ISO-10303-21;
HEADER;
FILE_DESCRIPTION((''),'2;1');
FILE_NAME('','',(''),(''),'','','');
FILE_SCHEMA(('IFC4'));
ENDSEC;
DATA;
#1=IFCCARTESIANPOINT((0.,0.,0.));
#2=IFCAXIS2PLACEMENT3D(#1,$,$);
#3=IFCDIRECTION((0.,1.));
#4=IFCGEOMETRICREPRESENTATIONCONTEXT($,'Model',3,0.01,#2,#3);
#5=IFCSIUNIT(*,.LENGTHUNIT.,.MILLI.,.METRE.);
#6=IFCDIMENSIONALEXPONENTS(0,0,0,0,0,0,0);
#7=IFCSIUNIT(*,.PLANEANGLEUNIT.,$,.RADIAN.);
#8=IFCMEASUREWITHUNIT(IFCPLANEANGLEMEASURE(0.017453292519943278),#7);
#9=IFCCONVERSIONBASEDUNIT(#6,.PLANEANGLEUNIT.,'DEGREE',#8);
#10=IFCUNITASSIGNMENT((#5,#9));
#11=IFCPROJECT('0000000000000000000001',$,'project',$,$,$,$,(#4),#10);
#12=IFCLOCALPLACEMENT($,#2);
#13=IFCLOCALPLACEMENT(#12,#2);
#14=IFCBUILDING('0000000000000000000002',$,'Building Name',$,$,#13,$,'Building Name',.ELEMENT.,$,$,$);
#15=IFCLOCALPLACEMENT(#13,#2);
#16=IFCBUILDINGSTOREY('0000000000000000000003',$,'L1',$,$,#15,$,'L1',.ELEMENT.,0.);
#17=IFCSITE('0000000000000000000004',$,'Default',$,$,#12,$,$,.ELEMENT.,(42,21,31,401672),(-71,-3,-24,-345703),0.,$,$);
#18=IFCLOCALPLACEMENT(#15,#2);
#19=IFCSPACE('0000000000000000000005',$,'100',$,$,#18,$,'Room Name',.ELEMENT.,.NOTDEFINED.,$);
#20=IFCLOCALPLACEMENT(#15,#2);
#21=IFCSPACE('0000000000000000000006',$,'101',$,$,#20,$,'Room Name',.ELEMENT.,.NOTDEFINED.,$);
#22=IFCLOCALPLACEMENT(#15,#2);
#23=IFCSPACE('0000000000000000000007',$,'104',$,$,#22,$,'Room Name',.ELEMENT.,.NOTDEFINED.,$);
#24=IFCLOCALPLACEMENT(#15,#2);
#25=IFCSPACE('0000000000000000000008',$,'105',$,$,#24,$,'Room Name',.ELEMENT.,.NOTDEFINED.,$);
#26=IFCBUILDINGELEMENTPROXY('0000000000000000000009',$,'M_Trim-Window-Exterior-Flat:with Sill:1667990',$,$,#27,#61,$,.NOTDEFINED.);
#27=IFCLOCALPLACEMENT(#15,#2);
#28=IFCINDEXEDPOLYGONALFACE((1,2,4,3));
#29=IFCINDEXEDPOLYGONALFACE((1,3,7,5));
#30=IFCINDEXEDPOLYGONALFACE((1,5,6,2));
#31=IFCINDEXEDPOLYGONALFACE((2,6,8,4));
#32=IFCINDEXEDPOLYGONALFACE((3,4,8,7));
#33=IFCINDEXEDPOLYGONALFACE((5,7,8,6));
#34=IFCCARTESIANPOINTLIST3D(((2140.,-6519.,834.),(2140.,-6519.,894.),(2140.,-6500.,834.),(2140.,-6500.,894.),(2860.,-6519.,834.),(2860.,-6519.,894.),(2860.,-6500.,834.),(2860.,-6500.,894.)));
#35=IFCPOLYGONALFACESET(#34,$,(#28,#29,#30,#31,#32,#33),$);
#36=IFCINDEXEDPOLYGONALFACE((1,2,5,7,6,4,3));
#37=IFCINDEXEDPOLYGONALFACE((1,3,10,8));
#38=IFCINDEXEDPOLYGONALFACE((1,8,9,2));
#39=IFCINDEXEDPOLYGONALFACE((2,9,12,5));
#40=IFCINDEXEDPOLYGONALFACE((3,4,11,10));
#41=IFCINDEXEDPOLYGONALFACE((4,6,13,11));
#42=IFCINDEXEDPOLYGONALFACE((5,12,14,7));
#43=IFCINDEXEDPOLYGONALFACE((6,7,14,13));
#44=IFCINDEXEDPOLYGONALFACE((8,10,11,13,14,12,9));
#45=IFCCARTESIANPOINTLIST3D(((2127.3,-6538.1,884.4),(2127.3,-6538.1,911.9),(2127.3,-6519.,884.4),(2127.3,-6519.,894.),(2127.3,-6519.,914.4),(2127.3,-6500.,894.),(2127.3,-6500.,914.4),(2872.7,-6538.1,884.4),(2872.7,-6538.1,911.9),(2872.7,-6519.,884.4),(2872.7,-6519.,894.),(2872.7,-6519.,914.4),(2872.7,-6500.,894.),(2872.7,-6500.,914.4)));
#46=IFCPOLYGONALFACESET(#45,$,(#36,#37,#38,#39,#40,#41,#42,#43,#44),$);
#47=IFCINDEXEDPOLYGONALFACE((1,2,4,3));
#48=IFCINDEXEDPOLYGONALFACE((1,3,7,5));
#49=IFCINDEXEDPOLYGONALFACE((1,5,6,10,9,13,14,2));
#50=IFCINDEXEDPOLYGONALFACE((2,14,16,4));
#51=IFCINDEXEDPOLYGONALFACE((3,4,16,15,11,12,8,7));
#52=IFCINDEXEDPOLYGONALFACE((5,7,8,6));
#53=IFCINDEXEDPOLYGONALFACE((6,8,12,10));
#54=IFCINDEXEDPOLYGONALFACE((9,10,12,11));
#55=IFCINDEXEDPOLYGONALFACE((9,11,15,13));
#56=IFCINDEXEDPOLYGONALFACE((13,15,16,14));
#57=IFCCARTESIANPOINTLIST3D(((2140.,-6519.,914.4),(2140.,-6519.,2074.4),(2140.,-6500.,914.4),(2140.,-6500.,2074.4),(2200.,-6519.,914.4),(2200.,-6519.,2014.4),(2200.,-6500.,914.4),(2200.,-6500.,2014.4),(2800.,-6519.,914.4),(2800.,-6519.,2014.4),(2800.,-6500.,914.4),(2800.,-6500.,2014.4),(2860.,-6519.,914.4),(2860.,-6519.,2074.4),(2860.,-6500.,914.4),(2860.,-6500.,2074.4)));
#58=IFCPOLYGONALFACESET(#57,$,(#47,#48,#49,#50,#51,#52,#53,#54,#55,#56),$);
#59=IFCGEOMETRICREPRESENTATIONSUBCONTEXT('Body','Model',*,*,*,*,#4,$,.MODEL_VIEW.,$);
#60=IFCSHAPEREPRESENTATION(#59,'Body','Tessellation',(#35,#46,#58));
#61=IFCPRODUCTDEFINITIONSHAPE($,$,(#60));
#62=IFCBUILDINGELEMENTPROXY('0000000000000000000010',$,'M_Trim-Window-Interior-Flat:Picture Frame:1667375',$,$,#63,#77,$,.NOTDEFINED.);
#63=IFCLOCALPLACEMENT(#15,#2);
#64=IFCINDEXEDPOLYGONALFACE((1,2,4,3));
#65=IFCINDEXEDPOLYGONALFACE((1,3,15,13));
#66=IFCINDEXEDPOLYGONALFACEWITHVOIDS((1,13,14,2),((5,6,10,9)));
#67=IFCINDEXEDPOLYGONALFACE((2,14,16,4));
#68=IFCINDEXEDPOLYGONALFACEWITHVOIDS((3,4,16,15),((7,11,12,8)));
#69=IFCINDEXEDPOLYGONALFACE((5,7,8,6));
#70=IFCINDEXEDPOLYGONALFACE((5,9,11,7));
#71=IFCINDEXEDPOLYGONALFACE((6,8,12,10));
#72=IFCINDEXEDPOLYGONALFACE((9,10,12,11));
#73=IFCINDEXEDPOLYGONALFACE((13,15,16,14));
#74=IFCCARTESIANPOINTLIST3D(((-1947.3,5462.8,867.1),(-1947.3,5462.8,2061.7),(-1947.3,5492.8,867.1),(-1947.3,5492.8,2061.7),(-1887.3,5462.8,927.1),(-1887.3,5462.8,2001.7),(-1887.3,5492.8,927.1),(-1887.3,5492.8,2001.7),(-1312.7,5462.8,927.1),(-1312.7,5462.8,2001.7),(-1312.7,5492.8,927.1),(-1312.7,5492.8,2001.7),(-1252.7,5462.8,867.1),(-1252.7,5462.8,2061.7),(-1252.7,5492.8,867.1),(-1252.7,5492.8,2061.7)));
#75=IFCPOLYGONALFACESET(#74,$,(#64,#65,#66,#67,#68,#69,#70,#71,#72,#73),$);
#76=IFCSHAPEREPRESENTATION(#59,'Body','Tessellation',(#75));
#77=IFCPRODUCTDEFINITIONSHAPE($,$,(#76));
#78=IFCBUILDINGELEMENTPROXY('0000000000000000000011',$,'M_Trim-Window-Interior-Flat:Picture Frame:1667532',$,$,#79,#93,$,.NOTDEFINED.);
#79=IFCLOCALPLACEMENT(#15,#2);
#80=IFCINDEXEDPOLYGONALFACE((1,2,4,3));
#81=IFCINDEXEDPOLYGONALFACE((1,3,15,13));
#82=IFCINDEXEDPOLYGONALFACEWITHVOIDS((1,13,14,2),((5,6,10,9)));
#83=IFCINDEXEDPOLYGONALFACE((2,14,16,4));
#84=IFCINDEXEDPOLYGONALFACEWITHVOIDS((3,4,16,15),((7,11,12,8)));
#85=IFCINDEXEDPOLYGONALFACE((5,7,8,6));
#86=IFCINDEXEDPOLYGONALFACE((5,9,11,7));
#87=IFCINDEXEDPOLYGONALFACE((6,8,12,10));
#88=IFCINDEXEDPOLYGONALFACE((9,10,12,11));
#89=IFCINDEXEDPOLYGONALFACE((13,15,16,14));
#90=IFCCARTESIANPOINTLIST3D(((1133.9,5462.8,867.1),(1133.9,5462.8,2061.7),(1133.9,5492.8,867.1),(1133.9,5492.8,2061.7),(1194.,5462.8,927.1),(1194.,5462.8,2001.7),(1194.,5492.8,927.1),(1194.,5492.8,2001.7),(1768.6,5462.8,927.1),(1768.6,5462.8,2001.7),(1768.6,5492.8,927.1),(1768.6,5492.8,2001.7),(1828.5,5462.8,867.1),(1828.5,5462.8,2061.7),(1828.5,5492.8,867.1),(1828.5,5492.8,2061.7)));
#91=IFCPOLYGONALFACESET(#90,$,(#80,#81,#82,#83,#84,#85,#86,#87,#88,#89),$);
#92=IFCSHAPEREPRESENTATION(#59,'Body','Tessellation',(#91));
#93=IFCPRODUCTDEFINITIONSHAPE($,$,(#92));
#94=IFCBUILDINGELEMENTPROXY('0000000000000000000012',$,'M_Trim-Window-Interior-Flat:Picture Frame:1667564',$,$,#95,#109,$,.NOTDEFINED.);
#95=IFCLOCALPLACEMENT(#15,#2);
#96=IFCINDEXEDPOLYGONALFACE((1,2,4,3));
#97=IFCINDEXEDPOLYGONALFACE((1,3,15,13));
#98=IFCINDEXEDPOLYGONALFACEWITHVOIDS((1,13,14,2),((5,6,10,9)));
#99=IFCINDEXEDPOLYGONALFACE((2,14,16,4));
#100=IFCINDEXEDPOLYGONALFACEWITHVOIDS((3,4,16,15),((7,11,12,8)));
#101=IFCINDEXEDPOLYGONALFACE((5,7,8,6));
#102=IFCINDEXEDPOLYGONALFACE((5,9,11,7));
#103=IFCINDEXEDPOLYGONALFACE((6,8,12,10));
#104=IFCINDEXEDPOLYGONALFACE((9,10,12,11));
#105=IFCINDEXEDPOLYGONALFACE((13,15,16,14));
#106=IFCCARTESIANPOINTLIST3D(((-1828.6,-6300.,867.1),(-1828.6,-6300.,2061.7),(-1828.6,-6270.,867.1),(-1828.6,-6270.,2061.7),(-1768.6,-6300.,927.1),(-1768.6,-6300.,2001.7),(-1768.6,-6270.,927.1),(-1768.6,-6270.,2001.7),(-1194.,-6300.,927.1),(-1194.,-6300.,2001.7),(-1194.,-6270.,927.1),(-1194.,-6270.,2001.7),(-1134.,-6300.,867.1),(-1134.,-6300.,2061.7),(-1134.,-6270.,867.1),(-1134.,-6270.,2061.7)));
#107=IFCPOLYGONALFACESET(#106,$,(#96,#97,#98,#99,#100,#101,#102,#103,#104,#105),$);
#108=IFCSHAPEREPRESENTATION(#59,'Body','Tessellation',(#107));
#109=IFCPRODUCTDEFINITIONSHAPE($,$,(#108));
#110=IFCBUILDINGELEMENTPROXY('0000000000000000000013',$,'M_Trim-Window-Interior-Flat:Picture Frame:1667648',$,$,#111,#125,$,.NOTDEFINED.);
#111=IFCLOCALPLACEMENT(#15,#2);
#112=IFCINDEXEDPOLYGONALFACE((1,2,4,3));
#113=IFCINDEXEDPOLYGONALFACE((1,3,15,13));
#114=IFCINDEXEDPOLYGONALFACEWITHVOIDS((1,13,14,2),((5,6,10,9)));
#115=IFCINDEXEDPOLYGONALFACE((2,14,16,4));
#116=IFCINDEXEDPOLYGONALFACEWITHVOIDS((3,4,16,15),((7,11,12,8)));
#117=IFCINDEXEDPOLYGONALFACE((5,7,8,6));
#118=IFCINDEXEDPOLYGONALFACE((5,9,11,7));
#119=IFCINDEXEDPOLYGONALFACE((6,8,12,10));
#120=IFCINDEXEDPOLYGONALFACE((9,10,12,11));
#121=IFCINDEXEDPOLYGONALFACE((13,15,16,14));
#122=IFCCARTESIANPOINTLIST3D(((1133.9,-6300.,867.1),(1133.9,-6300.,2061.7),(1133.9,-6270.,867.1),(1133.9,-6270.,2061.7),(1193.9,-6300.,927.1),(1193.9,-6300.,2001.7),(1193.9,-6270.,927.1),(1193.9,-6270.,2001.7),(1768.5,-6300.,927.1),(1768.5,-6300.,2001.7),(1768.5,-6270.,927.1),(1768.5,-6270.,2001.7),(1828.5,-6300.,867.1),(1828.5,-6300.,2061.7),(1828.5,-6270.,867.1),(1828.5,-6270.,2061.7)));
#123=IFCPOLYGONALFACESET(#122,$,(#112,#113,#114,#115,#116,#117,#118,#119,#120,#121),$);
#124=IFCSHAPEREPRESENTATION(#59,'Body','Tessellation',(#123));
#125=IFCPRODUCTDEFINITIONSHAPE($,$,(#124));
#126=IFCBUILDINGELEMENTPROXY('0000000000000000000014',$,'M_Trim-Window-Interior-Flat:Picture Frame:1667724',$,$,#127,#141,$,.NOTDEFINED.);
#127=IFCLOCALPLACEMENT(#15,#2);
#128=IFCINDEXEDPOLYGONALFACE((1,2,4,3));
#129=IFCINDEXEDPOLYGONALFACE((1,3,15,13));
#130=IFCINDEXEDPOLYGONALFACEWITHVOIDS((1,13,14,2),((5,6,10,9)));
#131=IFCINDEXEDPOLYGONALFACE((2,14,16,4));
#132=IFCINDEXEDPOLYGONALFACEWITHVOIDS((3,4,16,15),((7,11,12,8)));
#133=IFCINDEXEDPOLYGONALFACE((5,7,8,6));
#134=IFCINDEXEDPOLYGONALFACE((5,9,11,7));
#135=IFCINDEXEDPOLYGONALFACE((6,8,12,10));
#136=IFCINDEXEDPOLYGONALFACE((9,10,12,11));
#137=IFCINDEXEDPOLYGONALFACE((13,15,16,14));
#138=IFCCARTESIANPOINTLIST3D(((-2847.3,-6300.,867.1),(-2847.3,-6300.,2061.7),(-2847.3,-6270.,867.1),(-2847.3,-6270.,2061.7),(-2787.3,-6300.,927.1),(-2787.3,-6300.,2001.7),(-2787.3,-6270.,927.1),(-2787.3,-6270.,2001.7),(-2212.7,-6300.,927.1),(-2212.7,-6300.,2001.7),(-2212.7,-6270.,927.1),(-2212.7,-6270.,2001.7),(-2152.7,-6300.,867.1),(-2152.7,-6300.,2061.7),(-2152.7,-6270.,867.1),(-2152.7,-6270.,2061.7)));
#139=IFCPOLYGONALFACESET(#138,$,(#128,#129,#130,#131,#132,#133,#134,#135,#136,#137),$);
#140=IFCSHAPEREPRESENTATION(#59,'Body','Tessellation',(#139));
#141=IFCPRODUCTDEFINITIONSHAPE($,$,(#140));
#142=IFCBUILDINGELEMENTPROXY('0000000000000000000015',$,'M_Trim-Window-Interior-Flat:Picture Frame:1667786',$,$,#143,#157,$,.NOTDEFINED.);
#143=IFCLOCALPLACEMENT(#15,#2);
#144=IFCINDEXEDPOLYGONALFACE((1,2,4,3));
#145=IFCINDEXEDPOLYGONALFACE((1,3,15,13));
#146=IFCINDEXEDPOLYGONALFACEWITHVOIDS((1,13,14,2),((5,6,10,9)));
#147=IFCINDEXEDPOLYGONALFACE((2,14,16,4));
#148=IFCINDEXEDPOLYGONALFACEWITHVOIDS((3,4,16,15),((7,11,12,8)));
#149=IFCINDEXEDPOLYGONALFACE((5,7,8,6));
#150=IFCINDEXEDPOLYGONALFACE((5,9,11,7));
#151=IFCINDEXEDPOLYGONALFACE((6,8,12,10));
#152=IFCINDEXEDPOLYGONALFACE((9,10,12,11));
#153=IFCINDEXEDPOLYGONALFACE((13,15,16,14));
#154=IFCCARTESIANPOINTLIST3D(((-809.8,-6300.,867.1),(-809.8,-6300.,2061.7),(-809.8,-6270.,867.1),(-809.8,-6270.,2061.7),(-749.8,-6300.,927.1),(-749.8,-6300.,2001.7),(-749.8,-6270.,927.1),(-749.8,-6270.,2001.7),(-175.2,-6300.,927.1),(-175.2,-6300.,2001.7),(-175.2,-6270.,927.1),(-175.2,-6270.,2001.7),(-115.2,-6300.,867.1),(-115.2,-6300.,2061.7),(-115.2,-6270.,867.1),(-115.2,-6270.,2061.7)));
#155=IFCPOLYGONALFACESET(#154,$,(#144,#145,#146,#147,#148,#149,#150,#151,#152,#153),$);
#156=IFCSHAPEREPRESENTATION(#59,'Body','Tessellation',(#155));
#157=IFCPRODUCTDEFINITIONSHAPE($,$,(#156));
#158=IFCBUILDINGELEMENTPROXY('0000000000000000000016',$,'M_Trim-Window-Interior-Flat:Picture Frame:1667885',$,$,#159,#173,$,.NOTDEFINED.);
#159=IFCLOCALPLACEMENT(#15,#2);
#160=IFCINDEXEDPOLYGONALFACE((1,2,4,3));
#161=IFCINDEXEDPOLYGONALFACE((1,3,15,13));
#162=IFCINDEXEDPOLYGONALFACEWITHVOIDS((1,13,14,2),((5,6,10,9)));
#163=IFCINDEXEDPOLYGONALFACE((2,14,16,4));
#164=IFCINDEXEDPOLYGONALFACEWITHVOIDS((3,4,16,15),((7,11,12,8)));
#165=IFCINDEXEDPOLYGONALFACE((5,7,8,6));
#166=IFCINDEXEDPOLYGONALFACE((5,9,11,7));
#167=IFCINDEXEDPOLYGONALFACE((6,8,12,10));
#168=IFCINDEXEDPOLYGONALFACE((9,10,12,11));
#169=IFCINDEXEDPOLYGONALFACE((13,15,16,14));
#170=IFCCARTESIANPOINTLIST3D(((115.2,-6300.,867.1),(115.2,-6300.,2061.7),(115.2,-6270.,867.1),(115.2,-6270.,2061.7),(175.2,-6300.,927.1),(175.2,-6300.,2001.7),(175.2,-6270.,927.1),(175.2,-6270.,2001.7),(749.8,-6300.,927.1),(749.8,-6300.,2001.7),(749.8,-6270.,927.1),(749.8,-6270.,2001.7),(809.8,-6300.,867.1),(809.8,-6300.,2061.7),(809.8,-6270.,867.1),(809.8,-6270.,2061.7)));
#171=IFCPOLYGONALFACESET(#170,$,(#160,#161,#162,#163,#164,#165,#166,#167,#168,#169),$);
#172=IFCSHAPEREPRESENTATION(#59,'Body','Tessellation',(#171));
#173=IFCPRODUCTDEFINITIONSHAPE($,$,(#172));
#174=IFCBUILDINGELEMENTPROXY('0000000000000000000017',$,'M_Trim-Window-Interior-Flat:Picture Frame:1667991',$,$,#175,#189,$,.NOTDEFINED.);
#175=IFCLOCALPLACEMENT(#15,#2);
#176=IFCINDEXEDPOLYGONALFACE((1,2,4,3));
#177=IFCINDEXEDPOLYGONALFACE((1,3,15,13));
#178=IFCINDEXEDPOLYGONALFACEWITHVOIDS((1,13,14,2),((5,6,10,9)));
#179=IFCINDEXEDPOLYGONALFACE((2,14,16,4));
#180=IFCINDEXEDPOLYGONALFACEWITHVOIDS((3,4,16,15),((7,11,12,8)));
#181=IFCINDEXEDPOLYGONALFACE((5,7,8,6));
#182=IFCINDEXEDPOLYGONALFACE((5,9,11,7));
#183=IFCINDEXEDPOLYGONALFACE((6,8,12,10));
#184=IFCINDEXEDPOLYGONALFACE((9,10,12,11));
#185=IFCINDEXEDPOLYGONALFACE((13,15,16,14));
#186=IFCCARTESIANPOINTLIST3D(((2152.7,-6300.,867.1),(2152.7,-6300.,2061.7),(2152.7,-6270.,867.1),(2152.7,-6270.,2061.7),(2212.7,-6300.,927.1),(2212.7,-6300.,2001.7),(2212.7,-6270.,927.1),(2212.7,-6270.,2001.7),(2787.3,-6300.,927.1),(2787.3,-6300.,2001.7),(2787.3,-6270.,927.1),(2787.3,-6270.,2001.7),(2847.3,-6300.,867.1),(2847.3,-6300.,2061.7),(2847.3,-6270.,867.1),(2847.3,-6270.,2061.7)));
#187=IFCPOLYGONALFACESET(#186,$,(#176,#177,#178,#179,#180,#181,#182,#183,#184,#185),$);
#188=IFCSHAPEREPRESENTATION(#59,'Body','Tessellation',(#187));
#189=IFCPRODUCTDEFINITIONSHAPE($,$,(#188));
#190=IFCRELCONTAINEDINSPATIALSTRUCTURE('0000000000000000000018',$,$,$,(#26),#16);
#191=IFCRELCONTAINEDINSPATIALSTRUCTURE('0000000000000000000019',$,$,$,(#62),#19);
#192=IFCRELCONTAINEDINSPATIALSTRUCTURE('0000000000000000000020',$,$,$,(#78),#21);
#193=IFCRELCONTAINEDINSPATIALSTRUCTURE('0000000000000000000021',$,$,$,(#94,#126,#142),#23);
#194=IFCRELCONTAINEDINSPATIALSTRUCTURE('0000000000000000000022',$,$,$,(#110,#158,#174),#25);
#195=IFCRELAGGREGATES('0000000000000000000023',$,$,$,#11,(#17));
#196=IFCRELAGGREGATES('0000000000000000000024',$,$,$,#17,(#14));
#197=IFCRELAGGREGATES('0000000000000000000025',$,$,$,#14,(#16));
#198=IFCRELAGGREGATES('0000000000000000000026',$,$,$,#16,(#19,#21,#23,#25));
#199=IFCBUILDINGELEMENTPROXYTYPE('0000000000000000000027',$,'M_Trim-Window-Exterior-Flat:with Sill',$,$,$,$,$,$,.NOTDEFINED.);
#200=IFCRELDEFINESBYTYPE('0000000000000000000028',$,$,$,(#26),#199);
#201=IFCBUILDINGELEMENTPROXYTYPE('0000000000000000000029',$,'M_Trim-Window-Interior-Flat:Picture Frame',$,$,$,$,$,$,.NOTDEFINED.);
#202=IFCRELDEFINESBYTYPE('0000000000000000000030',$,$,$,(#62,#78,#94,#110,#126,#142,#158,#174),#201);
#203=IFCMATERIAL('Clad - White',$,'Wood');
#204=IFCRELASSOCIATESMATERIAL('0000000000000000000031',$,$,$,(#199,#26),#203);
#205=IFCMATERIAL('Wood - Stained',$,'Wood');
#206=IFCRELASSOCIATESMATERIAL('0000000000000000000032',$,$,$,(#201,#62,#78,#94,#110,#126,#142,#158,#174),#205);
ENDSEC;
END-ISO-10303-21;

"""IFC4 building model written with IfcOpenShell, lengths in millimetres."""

from ifc_helpers import new_model, entity, si_unit, converted_unit, direction, frame, origin, place, context, subcontext, project, spatial, indexed_curve, outline, extrude, source, transform, mapped, material, type_object, type_shapes, element, save


model = new_model("IFC4")

# Units and contexts
model_context = context("Model", 3, precision=0.01, world=origin(), true_north=direction((0.0, 1.0)))
body_context = subcontext(model_context, "Body", "Model", "MODEL_VIEW")
ifc_project = project(units=[si_unit("LENGTHUNIT", "METRE", prefix="MILLI"), converted_unit("PLANEANGLEUNIT", "DEGREE", entity("IfcPlaneAngleMeasure", 0.017453292519943278), si_unit("PLANEANGLEUNIT", "RADIAN"), dimensions=[0, 0, 0, 0, 0, 0, 0])], contexts=[model_context])

# Site, building, storey
site_placement = place(None, origin())
site = spatial("IfcSite", under=ifc_project, at=site_placement, Name="Default", CompositionType="ELEMENT", RefLatitude=(42, 21, 31, 401672), RefLongitude=(-71, -3, -24, -345703), RefElevation=0.0)
building_placement = place(site_placement, origin())
building = spatial("IfcBuilding", under=site, at=building_placement, Name="Building Name", LongName="Building Name", CompositionType="ELEMENT")
storey_placement = place(building_placement, origin())
storey = spatial("IfcBuildingStorey", under=building, at=storey_placement, Name="L1", LongName="L1", CompositionType="ELEMENT", Elevation=0.0)

# Building element proxy
ifc_material_1 = material(Name="Clad - White", Category="Wood")
ifc_material_2 = material(Name="Wood - Stained", Category="Wood")
building_element_proxy_type_1 = type_object("IfcBuildingElementProxyType", Name="M_Trim-Window-Exterior-Flat:with Sill", PredefinedType="NOTDEFINED", material=ifc_material_1)
shared_shape_1 = source(origin(), body_context, "Body", "SweptSolid", [
    extrude(outline(indexed_curve([(-360.0, -30.0), (360.0, -30.0), (360.0, 30.0), (-360.0, 30.0), (-360.0, -30.0)], self_intersect=False)), frame((0.0, -1150.4, 0.0), z_axis=(0.0, 0.0, 1.0), x_axis=(-1.0, 0.0, 0.0)), (0.0, 0.0, 1.0), 19.0),
    extrude(outline(indexed_curve([(-19.0, -15.2), (0.0, -15.2), (0.0, -5.7), (19.0, -5.7), (19.0, 14.8), (0.0, 14.8), (-19.0, 12.3), (-19.0, -15.2)], self_intersect=False)), frame((-372.7, -1114.8, 19.0), z_axis=(1.0, 0.0, 0.0), x_axis=(0.0, 0.0, -1.0)), (0.0, 0.0, 1.0), 745.4),
    extrude(outline(indexed_curve([(-595.0, -360.0), (565.0, -360.0), (565.0, -300.0), (-535.0, -300.0), (-535.0, 300.0), (565.0, 300.0), (565.0, 360.0), (-595.0, 360.0), (-595.0, -360.0)], self_intersect=False)), frame((0.0, -535.0, 0.0), z_axis=(0.0, 0.0, 1.0), x_axis=(0.0, -1.0, 0.0)), (0.0, 0.0, 1.0), 19.0),
])
type_shapes(building_element_proxy_type_1, [shared_shape_1])
for number, where, z_axis, x_axis, name in (
    (1, (2500.0, -6500.0, 2014.4), (0.0, -1.0, 0.0), (1.0, 0.0, 0.0), "M_Trim-Window-Exterior-Flat:with Sill:1667990"),
):
    element("IfcBuildingElementProxy", number, at=place(storey_placement, frame(where, z_axis=z_axis, x_axis=x_axis)), inside=storey, type_object=building_element_proxy_type_1, material=ifc_material_1, Name=name, PredefinedType="NOTDEFINED", context=body_context, shape_type="MappedRepresentation", body=[
        mapped(shared_shape_1, transform((0.0, 0.0, 0.0), scale=1.0)),
    ])

# Shared definitions
space_1_placement = place(storey_placement, origin())
space_1 = spatial("IfcSpace", under=storey, at=space_1_placement, Name="100", LongName="Room Name", CompositionType="ELEMENT", PredefinedType="NOTDEFINED")

# Building element proxy
building_element_proxy_type_2 = type_object("IfcBuildingElementProxyType", Name="M_Trim-Window-Interior-Flat:Picture Frame", PredefinedType="NOTDEFINED", material=ifc_material_2)
shared_shape_2 = source(origin(), body_context, "Body", "SweptSolid", [
    extrude(outline(indexed_curve([(-347.3, -597.3), (347.3, -597.3), (347.3, 597.3), (-347.3, 597.3), (-347.3, -597.3)], self_intersect=False), holes=[indexed_curve([(-287.3, -537.3), (-287.3, 537.3), (287.3, 537.3), (287.3, -537.3), (-287.3, -537.3)], self_intersect=False)]), frame((0.0, -550.0, 0.0), z_axis=(0.0, 0.0, 1.0), x_axis=(-1.0, 0.0, 0.0)), (0.0, 0.0, 1.0), 30.0),
])
type_shapes(building_element_proxy_type_2, [shared_shape_2])
proxy_1_placement = place(space_1_placement, frame((-1600.0, 5492.8, 2014.4), z_axis=(0.0, -1.0, 0.0), x_axis=(1.0, 0.0, 0.0)))
element("IfcBuildingElementProxy", 2, at=proxy_1_placement, inside=space_1, type_object=building_element_proxy_type_2, material=ifc_material_2, Name="M_Trim-Window-Interior-Flat:Picture Frame:1667375", PredefinedType="NOTDEFINED", context=body_context, shape_type="MappedRepresentation", body=[
    mapped(shared_shape_2, transform((0.0, 0.0, 0.0), scale=1.0)),
])

# Shared definitions
space_2_placement = place(storey_placement, origin())
space_2 = spatial("IfcSpace", under=storey, at=space_2_placement, Name="101", LongName="Room Name", CompositionType="ELEMENT", PredefinedType="NOTDEFINED")

# Building element proxy
proxy_2_placement = place(space_2_placement, frame((1481.2, 5492.8, 2014.4), z_axis=(0.0, -1.0, 0.0), x_axis=(1.0, 0.0, 0.0)))
element("IfcBuildingElementProxy", 3, at=proxy_2_placement, inside=space_2, type_object=building_element_proxy_type_2, material=ifc_material_2, Name="M_Trim-Window-Interior-Flat:Picture Frame:1667532", PredefinedType="NOTDEFINED", context=body_context, shape_type="MappedRepresentation", body=[
    mapped(shared_shape_2, transform((0.0, 0.0, 0.0), scale=1.0)),
])

# Shared definitions
space_3_placement = place(storey_placement, origin())
space_3 = spatial("IfcSpace", under=storey, at=space_3_placement, Name="104", LongName="Room Name", CompositionType="ELEMENT", PredefinedType="NOTDEFINED")

# Building element proxy
proxy_3_placement = place(space_3_placement, frame((-1481.3, -6300.0, 2014.4), z_axis=(0.0, 1.0, 0.0), x_axis=(-1.0, 0.0, 0.0)))
element("IfcBuildingElementProxy", 4, at=proxy_3_placement, inside=space_3, type_object=building_element_proxy_type_2, material=ifc_material_2, Name="M_Trim-Window-Interior-Flat:Picture Frame:1667564", PredefinedType="NOTDEFINED", context=body_context, shape_type="MappedRepresentation", body=[
    mapped(shared_shape_2, transform((0.0, 0.0, 0.0), scale=1.0)),
])

# Shared definitions
space_4_placement = place(storey_placement, origin())
space_4 = spatial("IfcSpace", under=storey, at=space_4_placement, Name="105", LongName="Room Name", CompositionType="ELEMENT", PredefinedType="NOTDEFINED")

# Building element proxies
proxy_4_placement = place(space_4_placement, frame((1481.2, -6300.0, 2014.4), z_axis=(0.0, 1.0, 0.0), x_axis=(-1.0, 0.0, 0.0)))
element("IfcBuildingElementProxy", 5, at=proxy_4_placement, inside=space_4, type_object=building_element_proxy_type_2, material=ifc_material_2, Name="M_Trim-Window-Interior-Flat:Picture Frame:1667648", PredefinedType="NOTDEFINED", context=body_context, shape_type="MappedRepresentation", body=[
    mapped(shared_shape_2, transform((0.0, 0.0, 0.0), scale=1.0)),
])
for number, where, z_axis, x_axis, name in (
    (6, (-2500.0, -6300.0, 2014.4), (0.0, 1.0, 0.0), (-1.0, 0.0, 0.0), "M_Trim-Window-Interior-Flat:Picture Frame:1667724"),
    (7, (-462.5, -6300.0, 2014.4), (0.0, 1.0, 0.0), (-1.0, 0.0, 0.0), "M_Trim-Window-Interior-Flat:Picture Frame:1667786"),
):
    element("IfcBuildingElementProxy", number, at=place(space_3_placement, frame(where, z_axis=z_axis, x_axis=x_axis)), inside=space_3, type_object=building_element_proxy_type_2, material=ifc_material_2, Name=name, PredefinedType="NOTDEFINED", context=body_context, shape_type="MappedRepresentation", body=[
        mapped(shared_shape_2, transform((0.0, 0.0, 0.0), scale=1.0)),
    ])
for number, where, z_axis, x_axis, name in (
    (8, (462.5, -6300.0, 2014.4), (0.0, 1.0, 0.0), (-1.0, 0.0, 0.0), "M_Trim-Window-Interior-Flat:Picture Frame:1667885"),
    (9, (2500.0, -6300.0, 2014.4), (0.0, 1.0, 0.0), (-1.0, 0.0, 0.0), "M_Trim-Window-Interior-Flat:Picture Frame:1667991"),
):
    element("IfcBuildingElementProxy", number, at=place(space_4_placement, frame(where, z_axis=z_axis, x_axis=x_axis)), inside=space_4, type_object=building_element_proxy_type_2, material=ifc_material_2, Name=name, PredefinedType="NOTDEFINED", context=body_context, shape_type="MappedRepresentation", body=[
        mapped(shared_shape_2, transform((0.0, 0.0, 0.0), scale=1.0)),
    ])

save(model, "model.ifc")
